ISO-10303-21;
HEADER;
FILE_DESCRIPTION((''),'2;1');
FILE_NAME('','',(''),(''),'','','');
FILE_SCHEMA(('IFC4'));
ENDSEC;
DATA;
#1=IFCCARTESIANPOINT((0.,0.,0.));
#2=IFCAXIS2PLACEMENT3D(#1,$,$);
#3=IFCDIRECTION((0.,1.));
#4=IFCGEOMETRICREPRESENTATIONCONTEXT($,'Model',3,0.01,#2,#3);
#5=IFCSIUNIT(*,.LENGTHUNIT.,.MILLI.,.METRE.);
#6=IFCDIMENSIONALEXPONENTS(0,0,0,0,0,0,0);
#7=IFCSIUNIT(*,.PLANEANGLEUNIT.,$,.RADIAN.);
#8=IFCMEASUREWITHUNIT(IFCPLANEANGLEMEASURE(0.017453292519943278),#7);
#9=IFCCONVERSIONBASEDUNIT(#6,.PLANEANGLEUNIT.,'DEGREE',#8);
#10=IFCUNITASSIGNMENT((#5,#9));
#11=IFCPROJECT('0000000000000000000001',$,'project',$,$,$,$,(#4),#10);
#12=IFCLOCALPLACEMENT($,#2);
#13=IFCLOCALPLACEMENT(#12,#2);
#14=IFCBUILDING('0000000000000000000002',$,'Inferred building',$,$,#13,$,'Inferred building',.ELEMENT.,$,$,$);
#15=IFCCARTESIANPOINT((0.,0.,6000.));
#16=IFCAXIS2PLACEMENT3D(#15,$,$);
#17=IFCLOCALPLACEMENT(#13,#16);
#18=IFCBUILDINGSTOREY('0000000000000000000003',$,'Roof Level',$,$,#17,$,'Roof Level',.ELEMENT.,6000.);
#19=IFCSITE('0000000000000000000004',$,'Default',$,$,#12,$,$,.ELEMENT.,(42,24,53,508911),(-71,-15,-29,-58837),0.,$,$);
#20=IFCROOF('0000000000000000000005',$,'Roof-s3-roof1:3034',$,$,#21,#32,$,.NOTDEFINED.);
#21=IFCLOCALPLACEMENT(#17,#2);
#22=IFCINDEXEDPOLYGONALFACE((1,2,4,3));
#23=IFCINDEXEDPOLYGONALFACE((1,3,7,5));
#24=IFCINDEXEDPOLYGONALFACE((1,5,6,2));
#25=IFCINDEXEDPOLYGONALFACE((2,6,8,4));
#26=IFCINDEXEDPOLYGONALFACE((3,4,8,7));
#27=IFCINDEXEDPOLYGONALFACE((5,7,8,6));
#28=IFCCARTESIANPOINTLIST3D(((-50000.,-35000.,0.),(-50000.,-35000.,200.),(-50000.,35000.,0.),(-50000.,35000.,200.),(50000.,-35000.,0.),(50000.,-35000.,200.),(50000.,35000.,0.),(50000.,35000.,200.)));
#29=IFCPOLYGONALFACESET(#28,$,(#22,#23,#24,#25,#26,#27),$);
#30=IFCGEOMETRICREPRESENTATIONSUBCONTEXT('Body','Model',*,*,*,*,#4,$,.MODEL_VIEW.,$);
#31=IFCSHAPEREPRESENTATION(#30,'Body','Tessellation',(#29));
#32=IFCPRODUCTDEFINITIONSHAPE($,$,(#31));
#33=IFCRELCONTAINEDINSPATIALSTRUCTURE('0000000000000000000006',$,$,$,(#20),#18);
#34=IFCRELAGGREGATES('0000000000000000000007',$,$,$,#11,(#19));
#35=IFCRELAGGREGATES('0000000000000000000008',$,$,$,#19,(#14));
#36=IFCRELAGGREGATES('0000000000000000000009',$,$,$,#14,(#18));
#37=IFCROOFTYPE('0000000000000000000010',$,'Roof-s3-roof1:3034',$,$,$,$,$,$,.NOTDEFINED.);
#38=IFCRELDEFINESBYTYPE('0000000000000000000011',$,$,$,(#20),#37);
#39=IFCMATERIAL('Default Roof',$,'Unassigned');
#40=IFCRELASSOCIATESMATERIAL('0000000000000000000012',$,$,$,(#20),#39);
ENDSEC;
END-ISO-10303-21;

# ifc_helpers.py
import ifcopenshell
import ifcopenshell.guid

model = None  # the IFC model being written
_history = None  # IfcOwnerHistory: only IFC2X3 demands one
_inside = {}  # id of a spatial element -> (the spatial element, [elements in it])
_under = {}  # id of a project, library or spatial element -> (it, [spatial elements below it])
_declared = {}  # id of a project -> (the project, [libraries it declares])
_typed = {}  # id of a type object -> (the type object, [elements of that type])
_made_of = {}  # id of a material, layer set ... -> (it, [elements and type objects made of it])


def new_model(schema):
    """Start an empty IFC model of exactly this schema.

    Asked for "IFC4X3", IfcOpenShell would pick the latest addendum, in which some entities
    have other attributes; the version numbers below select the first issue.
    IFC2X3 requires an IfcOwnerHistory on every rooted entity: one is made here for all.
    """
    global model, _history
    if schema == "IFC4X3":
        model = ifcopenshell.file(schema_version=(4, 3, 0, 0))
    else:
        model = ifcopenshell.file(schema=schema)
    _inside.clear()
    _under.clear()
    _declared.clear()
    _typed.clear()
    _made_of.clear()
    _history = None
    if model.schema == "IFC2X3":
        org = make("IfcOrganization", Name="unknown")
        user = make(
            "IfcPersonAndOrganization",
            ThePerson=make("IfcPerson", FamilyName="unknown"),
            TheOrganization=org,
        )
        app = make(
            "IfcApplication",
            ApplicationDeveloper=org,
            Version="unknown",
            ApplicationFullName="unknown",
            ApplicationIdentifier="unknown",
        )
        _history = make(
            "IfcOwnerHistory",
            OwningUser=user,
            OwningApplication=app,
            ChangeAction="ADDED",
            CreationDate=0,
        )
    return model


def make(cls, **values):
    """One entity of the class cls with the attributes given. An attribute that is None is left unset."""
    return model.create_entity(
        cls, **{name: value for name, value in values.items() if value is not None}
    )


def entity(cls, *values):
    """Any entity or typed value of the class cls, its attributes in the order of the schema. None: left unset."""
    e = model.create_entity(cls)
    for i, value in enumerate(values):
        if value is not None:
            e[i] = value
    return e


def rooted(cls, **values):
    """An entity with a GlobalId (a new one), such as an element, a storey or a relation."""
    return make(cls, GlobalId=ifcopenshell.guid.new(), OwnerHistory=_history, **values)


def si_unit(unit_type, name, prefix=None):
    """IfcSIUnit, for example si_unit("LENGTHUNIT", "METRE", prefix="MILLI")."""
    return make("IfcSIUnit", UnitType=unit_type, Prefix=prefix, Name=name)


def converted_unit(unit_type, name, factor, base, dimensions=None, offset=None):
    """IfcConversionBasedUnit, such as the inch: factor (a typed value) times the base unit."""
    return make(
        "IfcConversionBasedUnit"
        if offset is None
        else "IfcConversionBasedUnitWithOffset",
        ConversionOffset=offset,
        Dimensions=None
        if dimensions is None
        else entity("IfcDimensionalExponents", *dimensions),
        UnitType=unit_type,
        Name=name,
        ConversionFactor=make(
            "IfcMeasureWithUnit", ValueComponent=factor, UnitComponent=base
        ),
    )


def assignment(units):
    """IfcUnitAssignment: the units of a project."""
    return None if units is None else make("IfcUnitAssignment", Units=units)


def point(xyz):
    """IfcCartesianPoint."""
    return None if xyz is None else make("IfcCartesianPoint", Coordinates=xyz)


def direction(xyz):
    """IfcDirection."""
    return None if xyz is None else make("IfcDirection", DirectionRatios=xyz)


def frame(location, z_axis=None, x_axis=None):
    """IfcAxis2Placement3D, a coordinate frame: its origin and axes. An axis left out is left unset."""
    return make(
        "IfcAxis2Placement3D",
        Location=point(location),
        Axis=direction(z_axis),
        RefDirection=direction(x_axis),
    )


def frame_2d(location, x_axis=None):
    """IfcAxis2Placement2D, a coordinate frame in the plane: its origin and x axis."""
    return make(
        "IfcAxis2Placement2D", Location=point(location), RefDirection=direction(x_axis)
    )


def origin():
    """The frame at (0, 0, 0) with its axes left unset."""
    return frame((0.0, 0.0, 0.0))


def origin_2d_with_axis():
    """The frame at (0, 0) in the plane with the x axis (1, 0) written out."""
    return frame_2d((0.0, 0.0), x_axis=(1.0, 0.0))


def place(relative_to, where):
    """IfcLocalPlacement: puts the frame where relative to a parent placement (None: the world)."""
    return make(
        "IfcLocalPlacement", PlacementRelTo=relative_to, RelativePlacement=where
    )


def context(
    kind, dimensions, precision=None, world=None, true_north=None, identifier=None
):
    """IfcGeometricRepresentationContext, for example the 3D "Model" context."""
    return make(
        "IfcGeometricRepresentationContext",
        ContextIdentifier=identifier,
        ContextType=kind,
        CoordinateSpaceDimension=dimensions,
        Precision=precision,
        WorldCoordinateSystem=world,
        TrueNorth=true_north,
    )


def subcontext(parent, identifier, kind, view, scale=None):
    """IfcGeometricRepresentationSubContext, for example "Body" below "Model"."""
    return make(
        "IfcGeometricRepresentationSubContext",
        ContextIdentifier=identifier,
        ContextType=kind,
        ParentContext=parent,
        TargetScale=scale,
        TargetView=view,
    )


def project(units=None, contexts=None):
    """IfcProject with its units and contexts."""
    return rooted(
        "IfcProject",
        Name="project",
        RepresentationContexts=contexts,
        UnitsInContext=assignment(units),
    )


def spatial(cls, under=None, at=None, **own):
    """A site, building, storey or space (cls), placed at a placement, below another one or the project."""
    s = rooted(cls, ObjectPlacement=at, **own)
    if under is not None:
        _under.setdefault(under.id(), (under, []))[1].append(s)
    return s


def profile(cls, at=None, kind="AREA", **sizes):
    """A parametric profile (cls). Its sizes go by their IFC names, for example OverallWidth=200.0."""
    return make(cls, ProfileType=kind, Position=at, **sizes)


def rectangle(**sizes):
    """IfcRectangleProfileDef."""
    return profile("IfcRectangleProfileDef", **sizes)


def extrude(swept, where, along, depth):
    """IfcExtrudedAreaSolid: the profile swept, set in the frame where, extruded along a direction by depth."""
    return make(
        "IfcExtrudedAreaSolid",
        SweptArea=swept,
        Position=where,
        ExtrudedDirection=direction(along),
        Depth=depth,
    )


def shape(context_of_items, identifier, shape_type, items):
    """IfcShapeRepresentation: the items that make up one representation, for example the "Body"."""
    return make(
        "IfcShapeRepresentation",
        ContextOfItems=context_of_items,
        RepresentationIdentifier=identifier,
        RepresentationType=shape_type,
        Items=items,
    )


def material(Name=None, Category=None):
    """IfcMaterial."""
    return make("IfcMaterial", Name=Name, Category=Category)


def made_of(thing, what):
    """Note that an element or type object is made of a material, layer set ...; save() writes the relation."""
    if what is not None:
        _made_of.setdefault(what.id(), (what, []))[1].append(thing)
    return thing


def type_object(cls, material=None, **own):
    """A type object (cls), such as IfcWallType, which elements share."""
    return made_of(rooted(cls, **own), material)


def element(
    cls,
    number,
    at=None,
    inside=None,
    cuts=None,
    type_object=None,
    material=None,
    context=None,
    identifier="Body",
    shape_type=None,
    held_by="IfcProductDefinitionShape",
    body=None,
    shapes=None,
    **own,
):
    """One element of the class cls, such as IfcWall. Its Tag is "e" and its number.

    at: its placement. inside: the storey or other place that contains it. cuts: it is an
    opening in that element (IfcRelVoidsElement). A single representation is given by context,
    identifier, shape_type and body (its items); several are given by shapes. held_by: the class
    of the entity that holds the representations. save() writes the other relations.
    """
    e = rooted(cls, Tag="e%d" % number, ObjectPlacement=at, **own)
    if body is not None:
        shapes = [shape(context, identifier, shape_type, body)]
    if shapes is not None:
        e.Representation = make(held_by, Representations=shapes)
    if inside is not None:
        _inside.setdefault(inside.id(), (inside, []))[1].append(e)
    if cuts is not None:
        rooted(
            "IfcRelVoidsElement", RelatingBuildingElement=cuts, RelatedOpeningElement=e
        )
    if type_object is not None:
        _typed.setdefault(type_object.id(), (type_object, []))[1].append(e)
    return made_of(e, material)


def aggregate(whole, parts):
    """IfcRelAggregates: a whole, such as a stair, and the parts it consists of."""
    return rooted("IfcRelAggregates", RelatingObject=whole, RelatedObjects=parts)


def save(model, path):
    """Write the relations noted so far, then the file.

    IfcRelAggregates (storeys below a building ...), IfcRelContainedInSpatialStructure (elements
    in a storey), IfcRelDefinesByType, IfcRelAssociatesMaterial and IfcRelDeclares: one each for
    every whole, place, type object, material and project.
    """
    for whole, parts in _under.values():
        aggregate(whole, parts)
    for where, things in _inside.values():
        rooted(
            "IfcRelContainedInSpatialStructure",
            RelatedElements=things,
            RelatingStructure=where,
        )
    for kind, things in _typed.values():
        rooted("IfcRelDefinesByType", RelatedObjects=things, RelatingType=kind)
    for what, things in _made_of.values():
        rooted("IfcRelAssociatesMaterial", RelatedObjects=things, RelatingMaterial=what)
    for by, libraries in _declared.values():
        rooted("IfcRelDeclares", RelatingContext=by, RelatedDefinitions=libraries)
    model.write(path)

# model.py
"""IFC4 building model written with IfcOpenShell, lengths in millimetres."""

from ifc_helpers import new_model, entity, si_unit, converted_unit, direction, frame, origin, origin_2d_with_axis, place, context, subcontext, project, spatial, rectangle, extrude, material, type_object, element, save


model = new_model("IFC4")

# Units and contexts
model_context = context("Model", 3, precision=0.01, world=origin(), true_north=direction((0.0, 1.0)))
body_context = subcontext(model_context, "Body", "Model", "MODEL_VIEW")
ifc_project = project(units=[si_unit("LENGTHUNIT", "METRE", prefix="MILLI"), converted_unit("PLANEANGLEUNIT", "DEGREE", entity("IfcPlaneAngleMeasure", 0.017453292519943278), si_unit("PLANEANGLEUNIT", "RADIAN"), dimensions=[0, 0, 0, 0, 0, 0, 0])], contexts=[model_context])

# Site, building, storey
site_placement = place(None, origin())
site = spatial("IfcSite", under=ifc_project, at=site_placement, Name="Default", CompositionType="ELEMENT", RefLatitude=(42, 24, 53, 508911), RefLongitude=(-71, -15, -29, -58837), RefElevation=0.0)
building_placement = place(site_placement, origin())
building = spatial("IfcBuilding", under=site, at=building_placement, Name="Inferred building", LongName="Inferred building", CompositionType="ELEMENT")
storey_placement = place(building_placement, frame((0.0, 0.0, 6000.0)))
storey = spatial("IfcBuildingStorey", under=building, at=storey_placement, Name="Roof Level", LongName="Roof Level", CompositionType="ELEMENT", Elevation=6000.0)

# Roof
ifc_material = material(Name="Default Roof", Category="Unassigned")
roof_type = type_object("IfcRoofType", Name="Roof-s3-roof1:3034", PredefinedType="NOTDEFINED")
roof_placement = place(storey_placement, origin())
element("IfcRoof", 1, at=roof_placement, inside=storey, type_object=roof_type, material=ifc_material, Name="Roof-s3-roof1:3034", PredefinedType="NOTDEFINED", context=body_context, shape_type="SweptSolid", body=[
    extrude(rectangle(XDim=100000.0, YDim=70000.0, at=origin_2d_with_axis()), origin(), (0.0, 0.0, 1.0), 200.0),
])

save(model, "model.ifc")
